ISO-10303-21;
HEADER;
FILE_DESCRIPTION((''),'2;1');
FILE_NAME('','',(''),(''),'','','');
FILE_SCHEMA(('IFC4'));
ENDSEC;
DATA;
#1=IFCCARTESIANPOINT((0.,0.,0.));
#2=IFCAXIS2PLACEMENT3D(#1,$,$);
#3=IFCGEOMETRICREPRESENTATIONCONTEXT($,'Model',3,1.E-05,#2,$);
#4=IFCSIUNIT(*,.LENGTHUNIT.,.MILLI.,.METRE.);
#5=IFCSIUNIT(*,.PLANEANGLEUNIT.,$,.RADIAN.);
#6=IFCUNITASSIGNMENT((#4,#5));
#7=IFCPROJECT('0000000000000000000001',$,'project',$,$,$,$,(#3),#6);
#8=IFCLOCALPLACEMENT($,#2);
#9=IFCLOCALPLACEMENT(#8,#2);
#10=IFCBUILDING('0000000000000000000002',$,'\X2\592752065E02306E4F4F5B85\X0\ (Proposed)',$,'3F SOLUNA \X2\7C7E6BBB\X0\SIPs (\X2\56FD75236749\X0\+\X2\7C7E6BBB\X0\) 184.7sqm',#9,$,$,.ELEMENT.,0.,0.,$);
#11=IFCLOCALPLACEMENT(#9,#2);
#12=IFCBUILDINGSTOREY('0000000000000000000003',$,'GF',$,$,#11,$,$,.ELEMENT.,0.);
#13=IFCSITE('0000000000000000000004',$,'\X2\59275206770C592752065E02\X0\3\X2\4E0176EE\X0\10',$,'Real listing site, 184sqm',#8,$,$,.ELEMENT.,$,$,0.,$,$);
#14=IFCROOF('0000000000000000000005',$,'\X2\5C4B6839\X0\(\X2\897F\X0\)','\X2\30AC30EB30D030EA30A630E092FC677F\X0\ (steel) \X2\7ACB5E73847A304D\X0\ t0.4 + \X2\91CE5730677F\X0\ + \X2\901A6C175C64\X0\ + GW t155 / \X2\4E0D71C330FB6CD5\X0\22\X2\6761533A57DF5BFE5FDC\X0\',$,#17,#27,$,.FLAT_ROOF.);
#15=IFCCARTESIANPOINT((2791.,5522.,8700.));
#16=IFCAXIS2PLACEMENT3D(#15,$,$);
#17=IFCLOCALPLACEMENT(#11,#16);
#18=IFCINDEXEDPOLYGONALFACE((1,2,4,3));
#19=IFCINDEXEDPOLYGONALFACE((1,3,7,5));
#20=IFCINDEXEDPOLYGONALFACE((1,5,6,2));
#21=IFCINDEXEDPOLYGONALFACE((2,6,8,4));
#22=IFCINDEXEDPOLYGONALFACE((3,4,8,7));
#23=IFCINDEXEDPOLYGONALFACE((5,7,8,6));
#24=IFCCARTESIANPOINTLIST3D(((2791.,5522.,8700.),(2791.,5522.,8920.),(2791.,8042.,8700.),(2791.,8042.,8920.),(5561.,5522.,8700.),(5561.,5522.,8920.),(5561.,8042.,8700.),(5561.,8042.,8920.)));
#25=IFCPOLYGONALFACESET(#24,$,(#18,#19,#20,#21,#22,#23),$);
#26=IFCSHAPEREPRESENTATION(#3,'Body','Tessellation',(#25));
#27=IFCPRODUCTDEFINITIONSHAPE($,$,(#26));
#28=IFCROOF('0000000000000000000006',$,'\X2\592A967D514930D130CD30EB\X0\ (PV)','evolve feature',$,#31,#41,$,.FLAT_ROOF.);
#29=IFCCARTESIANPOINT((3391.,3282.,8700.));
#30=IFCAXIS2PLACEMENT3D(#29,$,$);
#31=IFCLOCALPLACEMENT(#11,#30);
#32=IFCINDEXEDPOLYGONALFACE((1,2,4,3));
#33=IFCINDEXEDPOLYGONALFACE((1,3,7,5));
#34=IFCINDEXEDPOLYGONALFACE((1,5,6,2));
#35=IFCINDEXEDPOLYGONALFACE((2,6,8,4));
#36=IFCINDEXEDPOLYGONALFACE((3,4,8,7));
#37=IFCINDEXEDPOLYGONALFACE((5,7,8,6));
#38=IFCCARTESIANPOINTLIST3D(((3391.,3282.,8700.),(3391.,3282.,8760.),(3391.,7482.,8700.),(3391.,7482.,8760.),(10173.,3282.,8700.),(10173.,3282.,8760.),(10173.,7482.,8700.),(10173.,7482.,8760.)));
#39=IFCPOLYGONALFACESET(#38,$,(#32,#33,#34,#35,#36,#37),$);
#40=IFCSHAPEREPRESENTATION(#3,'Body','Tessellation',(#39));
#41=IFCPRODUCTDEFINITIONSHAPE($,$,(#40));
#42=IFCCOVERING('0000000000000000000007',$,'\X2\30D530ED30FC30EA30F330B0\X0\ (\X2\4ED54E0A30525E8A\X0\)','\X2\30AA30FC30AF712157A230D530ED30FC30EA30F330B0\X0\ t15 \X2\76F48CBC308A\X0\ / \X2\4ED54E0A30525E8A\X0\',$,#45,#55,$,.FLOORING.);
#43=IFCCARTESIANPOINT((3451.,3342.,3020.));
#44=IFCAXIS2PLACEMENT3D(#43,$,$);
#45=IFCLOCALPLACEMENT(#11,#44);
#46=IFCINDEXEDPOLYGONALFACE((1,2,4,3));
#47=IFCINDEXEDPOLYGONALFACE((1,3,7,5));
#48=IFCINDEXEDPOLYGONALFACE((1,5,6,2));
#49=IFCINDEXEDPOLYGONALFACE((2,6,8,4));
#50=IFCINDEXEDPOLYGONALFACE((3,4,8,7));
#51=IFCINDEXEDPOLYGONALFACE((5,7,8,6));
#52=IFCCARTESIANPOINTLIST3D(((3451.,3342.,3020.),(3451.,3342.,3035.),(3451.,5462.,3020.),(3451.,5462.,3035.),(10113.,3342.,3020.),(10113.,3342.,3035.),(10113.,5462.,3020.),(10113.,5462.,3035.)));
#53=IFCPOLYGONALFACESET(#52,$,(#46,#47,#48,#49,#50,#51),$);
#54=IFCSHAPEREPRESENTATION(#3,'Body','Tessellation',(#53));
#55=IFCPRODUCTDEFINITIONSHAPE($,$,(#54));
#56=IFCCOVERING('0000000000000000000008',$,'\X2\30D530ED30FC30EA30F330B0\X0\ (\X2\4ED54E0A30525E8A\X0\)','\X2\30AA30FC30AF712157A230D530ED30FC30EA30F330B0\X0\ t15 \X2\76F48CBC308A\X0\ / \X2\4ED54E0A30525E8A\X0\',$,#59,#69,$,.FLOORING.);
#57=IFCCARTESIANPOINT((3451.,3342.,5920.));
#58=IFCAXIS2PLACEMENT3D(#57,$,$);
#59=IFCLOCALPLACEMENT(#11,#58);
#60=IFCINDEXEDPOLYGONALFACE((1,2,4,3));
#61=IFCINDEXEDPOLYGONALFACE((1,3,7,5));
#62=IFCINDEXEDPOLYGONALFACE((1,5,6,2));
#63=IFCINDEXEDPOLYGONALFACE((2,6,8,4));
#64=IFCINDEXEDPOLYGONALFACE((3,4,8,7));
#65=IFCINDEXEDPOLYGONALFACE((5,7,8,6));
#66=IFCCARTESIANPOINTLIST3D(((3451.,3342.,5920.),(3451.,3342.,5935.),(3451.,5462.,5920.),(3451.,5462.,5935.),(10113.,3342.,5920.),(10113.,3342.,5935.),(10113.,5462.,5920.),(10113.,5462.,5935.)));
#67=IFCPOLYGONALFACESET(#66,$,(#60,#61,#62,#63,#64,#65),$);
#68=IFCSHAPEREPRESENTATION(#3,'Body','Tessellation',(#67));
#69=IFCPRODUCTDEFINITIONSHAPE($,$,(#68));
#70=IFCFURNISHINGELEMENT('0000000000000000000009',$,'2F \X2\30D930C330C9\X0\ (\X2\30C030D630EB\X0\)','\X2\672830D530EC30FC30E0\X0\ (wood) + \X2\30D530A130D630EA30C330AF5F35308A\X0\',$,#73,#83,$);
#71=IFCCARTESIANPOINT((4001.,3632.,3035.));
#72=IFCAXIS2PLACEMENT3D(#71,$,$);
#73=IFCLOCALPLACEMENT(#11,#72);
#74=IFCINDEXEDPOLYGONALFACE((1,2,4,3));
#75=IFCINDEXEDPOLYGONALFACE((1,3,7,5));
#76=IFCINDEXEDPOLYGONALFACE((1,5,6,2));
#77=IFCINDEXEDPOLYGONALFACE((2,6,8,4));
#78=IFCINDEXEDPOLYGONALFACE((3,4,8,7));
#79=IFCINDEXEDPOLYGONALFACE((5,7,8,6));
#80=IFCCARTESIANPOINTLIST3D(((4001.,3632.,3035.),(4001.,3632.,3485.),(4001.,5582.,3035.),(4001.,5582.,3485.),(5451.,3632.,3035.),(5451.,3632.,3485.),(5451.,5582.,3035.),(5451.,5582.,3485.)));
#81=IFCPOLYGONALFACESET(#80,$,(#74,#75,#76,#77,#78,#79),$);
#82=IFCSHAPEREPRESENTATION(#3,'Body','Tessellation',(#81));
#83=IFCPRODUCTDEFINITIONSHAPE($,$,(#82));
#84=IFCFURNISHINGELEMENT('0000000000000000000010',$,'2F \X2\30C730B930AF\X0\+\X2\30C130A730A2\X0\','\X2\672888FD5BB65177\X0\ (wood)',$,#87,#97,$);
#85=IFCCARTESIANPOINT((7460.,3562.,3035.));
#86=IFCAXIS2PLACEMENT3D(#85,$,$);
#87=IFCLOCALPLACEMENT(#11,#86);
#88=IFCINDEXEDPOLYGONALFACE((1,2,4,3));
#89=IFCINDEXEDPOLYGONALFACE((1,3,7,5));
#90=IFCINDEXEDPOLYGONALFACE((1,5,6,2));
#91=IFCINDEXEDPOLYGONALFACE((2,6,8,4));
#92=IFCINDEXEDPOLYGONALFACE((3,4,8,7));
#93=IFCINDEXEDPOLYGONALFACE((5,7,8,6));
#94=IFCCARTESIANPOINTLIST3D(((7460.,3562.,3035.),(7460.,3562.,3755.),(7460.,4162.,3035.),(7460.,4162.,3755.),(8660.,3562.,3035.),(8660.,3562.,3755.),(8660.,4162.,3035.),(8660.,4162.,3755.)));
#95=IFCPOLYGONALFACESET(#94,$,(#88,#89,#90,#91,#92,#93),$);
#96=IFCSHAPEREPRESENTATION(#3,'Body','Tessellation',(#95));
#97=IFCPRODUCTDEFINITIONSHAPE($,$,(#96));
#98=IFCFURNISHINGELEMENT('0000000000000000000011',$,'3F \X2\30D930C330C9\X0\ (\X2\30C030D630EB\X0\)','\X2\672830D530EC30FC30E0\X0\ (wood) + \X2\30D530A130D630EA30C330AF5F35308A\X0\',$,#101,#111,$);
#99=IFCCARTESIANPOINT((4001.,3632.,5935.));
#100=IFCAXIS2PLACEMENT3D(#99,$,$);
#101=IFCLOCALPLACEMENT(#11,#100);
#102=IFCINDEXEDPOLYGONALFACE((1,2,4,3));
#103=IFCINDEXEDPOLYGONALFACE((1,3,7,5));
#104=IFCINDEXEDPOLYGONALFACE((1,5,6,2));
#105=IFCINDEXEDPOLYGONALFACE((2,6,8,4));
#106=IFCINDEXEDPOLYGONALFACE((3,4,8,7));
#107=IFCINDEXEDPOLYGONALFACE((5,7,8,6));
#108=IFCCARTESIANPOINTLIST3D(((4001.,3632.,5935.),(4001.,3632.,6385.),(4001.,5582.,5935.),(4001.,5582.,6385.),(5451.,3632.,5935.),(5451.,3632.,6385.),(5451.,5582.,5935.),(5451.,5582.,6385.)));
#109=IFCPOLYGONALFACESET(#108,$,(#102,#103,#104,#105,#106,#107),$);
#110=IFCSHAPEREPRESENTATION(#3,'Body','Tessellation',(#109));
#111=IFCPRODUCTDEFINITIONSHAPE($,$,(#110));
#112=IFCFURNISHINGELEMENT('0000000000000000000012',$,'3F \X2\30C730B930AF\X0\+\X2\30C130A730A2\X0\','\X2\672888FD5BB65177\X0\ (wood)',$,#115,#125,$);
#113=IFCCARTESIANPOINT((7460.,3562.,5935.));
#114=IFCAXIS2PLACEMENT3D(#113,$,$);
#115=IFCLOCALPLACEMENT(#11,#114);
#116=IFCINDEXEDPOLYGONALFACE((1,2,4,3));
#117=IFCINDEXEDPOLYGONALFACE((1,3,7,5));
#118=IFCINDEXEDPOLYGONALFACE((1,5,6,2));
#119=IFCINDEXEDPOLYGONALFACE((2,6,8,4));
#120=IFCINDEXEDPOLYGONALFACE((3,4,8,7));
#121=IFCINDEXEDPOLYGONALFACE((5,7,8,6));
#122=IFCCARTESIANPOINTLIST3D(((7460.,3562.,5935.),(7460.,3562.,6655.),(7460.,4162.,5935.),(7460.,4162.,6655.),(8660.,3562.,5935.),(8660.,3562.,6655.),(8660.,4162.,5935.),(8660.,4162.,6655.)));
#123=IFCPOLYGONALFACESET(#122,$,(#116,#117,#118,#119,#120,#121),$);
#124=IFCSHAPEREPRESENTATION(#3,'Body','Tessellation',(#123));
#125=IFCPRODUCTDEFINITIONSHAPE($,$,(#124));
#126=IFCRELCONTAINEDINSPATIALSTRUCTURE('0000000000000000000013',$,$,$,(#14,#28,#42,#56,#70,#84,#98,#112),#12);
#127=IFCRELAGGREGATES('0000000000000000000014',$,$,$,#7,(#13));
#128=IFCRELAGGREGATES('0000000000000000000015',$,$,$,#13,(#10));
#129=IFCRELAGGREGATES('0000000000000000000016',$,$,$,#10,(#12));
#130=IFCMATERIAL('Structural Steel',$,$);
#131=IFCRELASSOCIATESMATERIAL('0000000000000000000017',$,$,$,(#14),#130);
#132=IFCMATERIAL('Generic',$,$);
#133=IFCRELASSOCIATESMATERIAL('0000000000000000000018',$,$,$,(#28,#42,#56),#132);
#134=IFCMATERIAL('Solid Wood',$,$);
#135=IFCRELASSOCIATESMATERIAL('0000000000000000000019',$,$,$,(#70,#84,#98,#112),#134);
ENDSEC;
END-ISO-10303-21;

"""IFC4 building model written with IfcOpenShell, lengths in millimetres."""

from ifc_helpers import new_model, si_unit, frame, frame_2d, origin, place, context, project, spatial, rectangle, extrude, material, element, save


model = new_model("IFC4")

# Units and contexts
model_context = context("Model", 3, precision=1e-05, world=origin())
ifc_project = project(units=[si_unit("LENGTHUNIT", "METRE", prefix="MILLI"), si_unit("PLANEANGLEUNIT", "RADIAN")], contexts=[model_context])

# Site, building, storey
site_placement = place(None, origin())
site = spatial("IfcSite", under=ifc_project, at=site_placement, Name="大分県大分市3丁目10", ObjectType="Real listing site, 184sqm", CompositionType="ELEMENT", RefElevation=0.0)
building_placement = place(site_placement, origin())
building = spatial("IfcBuilding", under=site, at=building_placement, Name="大分市の住宅 (Proposed)", ObjectType="3F SOLUNA 籾殻SIPs (国産杉+籾殻) 184.7sqm", CompositionType="ELEMENT", ElevationOfRefHeight=0.0, ElevationOfTerrain=0.0)
storey_placement = place(building_placement, origin())
storey = spatial("IfcBuildingStorey", under=building, at=storey_placement, Name="GF", CompositionType="ELEMENT", Elevation=0.0)

# Shared definitions
ifc_material_1 = material(Name="Solid Wood")

# Roofs
ifc_material_2 = material(Name="Structural Steel")
roof_1_placement = place(storey_placement, frame((2791.0, 5522.0, 8700.0)))
element("IfcRoof", 1, at=roof_1_placement, inside=storey, material=ifc_material_2, Name="屋根(西)", Description="ガルバリウム鋼板 (steel) 立平葺き t0.4 + 野地板 + 通気層 + GW t155 / 不燃・法22条区域対応", PredefinedType="FLAT_ROOF", context=model_context, shape_type="SweptSolid", body=[
    extrude(rectangle(XDim=2770.0, YDim=2520.0, at=frame_2d((1385.0, 1260.0))), frame((2791.0, 5522.0, 8700.0)), (0.0, 0.0, 1.0), 220.0),
])
ifc_material_3 = material(Name="Generic")
roof_2_placement = place(storey_placement, frame((3391.0, 3282.0, 8700.0)))
element("IfcRoof", 2, at=roof_2_placement, inside=storey, material=ifc_material_3, Name="太陽光パネル (PV)", Description="evolve feature", PredefinedType="FLAT_ROOF", context=model_context, shape_type="SweptSolid", body=[
    extrude(rectangle(XDim=6782.0, YDim=4200.0, at=frame_2d((3391.0, 2100.0))), frame((3391.0, 3282.0, 8700.0)), (0.0, 0.0, 1.0), 60.0),
])

# Coverings
covering_1_placement = place(storey_placement, frame((3451.0, 3342.0, 3020.0)))
element("IfcCovering", 3, at=covering_1_placement, inside=storey, material=ifc_material_3, Name="フローリング (仕上げ床)", Description="オーク無垢フローリング t15 直貼り / 仕上げ床", PredefinedType="FLOORING", context=model_context, shape_type="SweptSolid", body=[
    extrude(rectangle(XDim=6662.0, YDim=2120.0, at=frame_2d((3331.0, 1060.0))), frame((3451.0, 3342.0, 3020.0)), (0.0, 0.0, 1.0), 15.0),
])
covering_2_placement = place(storey_placement, frame((3451.0, 3342.0, 5920.0)))
element("IfcCovering", 4, at=covering_2_placement, inside=storey, material=ifc_material_3, Name="フローリング (仕上げ床)", Description="オーク無垢フローリング t15 直貼り / 仕上げ床", PredefinedType="FLOORING", context=model_context, shape_type="SweptSolid", body=[
    extrude(rectangle(XDim=6662.0, YDim=2120.0, at=frame_2d((3331.0, 1060.0))), frame((3451.0, 3342.0, 5920.0)), (0.0, 0.0, 1.0), 15.0),
])

# Furnishing elements
furnishing_1_placement = place(storey_placement, frame((4001.0, 3632.0, 3035.0)))
element("IfcFurnishingElement", 5, at=furnishing_1_placement, inside=storey, material=ifc_material_1, Name="2F ベッド (ダブル)", Description="木フレーム (wood) + ファブリック張り", context=model_context, shape_type="SweptSolid", body=[
    extrude(rectangle(XDim=1450.0, YDim=1950.0, at=frame_2d((725.0, 975.0))), frame((4001.0, 3632.0, 3035.0)), (0.0, 0.0, 1.0), 450.0),
])
furnishing_2_placement = place(storey_placement, frame((7460.0, 3562.0, 3035.0)))
element("IfcFurnishingElement", 6, at=furnishing_2_placement, inside=storey, material=ifc_material_1, Name="2F デスク+チェア", Description="木製家具 (wood)", context=model_context, shape_type="SweptSolid", body=[
    extrude(rectangle(XDim=1200.0, YDim=600.0, at=frame_2d((600.0, 300.0))), frame((7460.0, 3562.0, 3035.0)), (0.0, 0.0, 1.0), 720.0),
])
furnishing_3_placement = place(storey_placement, frame((4001.0, 3632.0, 5935.0)))
element("IfcFurnishingElement", 7, at=furnishing_3_placement, inside=storey, material=ifc_material_1, Name="3F ベッド (ダブル)", Description="木フレーム (wood) + ファブリック張り", context=model_context, shape_type="SweptSolid", body=[
    extrude(rectangle(XDim=1450.0, YDim=1950.0, at=frame_2d((725.0, 975.0))), frame((4001.0, 3632.0, 5935.0)), (0.0, 0.0, 1.0), 450.0),
])
furnishing_4_placement = place(storey_placement, frame((7460.0, 3562.0, 5935.0)))
element("IfcFurnishingElement", 8, at=furnishing_4_placement, inside=storey, material=ifc_material_1, Name="3F デスク+チェア", Description="木製家具 (wood)", context=model_context, shape_type="SweptSolid", body=[
    extrude(rectangle(XDim=1200.0, YDim=600.0, at=frame_2d((600.0, 300.0))), frame((7460.0, 3562.0, 5935.0)), (0.0, 0.0, 1.0), 720.0),
])

save(model, "model.ifc")
